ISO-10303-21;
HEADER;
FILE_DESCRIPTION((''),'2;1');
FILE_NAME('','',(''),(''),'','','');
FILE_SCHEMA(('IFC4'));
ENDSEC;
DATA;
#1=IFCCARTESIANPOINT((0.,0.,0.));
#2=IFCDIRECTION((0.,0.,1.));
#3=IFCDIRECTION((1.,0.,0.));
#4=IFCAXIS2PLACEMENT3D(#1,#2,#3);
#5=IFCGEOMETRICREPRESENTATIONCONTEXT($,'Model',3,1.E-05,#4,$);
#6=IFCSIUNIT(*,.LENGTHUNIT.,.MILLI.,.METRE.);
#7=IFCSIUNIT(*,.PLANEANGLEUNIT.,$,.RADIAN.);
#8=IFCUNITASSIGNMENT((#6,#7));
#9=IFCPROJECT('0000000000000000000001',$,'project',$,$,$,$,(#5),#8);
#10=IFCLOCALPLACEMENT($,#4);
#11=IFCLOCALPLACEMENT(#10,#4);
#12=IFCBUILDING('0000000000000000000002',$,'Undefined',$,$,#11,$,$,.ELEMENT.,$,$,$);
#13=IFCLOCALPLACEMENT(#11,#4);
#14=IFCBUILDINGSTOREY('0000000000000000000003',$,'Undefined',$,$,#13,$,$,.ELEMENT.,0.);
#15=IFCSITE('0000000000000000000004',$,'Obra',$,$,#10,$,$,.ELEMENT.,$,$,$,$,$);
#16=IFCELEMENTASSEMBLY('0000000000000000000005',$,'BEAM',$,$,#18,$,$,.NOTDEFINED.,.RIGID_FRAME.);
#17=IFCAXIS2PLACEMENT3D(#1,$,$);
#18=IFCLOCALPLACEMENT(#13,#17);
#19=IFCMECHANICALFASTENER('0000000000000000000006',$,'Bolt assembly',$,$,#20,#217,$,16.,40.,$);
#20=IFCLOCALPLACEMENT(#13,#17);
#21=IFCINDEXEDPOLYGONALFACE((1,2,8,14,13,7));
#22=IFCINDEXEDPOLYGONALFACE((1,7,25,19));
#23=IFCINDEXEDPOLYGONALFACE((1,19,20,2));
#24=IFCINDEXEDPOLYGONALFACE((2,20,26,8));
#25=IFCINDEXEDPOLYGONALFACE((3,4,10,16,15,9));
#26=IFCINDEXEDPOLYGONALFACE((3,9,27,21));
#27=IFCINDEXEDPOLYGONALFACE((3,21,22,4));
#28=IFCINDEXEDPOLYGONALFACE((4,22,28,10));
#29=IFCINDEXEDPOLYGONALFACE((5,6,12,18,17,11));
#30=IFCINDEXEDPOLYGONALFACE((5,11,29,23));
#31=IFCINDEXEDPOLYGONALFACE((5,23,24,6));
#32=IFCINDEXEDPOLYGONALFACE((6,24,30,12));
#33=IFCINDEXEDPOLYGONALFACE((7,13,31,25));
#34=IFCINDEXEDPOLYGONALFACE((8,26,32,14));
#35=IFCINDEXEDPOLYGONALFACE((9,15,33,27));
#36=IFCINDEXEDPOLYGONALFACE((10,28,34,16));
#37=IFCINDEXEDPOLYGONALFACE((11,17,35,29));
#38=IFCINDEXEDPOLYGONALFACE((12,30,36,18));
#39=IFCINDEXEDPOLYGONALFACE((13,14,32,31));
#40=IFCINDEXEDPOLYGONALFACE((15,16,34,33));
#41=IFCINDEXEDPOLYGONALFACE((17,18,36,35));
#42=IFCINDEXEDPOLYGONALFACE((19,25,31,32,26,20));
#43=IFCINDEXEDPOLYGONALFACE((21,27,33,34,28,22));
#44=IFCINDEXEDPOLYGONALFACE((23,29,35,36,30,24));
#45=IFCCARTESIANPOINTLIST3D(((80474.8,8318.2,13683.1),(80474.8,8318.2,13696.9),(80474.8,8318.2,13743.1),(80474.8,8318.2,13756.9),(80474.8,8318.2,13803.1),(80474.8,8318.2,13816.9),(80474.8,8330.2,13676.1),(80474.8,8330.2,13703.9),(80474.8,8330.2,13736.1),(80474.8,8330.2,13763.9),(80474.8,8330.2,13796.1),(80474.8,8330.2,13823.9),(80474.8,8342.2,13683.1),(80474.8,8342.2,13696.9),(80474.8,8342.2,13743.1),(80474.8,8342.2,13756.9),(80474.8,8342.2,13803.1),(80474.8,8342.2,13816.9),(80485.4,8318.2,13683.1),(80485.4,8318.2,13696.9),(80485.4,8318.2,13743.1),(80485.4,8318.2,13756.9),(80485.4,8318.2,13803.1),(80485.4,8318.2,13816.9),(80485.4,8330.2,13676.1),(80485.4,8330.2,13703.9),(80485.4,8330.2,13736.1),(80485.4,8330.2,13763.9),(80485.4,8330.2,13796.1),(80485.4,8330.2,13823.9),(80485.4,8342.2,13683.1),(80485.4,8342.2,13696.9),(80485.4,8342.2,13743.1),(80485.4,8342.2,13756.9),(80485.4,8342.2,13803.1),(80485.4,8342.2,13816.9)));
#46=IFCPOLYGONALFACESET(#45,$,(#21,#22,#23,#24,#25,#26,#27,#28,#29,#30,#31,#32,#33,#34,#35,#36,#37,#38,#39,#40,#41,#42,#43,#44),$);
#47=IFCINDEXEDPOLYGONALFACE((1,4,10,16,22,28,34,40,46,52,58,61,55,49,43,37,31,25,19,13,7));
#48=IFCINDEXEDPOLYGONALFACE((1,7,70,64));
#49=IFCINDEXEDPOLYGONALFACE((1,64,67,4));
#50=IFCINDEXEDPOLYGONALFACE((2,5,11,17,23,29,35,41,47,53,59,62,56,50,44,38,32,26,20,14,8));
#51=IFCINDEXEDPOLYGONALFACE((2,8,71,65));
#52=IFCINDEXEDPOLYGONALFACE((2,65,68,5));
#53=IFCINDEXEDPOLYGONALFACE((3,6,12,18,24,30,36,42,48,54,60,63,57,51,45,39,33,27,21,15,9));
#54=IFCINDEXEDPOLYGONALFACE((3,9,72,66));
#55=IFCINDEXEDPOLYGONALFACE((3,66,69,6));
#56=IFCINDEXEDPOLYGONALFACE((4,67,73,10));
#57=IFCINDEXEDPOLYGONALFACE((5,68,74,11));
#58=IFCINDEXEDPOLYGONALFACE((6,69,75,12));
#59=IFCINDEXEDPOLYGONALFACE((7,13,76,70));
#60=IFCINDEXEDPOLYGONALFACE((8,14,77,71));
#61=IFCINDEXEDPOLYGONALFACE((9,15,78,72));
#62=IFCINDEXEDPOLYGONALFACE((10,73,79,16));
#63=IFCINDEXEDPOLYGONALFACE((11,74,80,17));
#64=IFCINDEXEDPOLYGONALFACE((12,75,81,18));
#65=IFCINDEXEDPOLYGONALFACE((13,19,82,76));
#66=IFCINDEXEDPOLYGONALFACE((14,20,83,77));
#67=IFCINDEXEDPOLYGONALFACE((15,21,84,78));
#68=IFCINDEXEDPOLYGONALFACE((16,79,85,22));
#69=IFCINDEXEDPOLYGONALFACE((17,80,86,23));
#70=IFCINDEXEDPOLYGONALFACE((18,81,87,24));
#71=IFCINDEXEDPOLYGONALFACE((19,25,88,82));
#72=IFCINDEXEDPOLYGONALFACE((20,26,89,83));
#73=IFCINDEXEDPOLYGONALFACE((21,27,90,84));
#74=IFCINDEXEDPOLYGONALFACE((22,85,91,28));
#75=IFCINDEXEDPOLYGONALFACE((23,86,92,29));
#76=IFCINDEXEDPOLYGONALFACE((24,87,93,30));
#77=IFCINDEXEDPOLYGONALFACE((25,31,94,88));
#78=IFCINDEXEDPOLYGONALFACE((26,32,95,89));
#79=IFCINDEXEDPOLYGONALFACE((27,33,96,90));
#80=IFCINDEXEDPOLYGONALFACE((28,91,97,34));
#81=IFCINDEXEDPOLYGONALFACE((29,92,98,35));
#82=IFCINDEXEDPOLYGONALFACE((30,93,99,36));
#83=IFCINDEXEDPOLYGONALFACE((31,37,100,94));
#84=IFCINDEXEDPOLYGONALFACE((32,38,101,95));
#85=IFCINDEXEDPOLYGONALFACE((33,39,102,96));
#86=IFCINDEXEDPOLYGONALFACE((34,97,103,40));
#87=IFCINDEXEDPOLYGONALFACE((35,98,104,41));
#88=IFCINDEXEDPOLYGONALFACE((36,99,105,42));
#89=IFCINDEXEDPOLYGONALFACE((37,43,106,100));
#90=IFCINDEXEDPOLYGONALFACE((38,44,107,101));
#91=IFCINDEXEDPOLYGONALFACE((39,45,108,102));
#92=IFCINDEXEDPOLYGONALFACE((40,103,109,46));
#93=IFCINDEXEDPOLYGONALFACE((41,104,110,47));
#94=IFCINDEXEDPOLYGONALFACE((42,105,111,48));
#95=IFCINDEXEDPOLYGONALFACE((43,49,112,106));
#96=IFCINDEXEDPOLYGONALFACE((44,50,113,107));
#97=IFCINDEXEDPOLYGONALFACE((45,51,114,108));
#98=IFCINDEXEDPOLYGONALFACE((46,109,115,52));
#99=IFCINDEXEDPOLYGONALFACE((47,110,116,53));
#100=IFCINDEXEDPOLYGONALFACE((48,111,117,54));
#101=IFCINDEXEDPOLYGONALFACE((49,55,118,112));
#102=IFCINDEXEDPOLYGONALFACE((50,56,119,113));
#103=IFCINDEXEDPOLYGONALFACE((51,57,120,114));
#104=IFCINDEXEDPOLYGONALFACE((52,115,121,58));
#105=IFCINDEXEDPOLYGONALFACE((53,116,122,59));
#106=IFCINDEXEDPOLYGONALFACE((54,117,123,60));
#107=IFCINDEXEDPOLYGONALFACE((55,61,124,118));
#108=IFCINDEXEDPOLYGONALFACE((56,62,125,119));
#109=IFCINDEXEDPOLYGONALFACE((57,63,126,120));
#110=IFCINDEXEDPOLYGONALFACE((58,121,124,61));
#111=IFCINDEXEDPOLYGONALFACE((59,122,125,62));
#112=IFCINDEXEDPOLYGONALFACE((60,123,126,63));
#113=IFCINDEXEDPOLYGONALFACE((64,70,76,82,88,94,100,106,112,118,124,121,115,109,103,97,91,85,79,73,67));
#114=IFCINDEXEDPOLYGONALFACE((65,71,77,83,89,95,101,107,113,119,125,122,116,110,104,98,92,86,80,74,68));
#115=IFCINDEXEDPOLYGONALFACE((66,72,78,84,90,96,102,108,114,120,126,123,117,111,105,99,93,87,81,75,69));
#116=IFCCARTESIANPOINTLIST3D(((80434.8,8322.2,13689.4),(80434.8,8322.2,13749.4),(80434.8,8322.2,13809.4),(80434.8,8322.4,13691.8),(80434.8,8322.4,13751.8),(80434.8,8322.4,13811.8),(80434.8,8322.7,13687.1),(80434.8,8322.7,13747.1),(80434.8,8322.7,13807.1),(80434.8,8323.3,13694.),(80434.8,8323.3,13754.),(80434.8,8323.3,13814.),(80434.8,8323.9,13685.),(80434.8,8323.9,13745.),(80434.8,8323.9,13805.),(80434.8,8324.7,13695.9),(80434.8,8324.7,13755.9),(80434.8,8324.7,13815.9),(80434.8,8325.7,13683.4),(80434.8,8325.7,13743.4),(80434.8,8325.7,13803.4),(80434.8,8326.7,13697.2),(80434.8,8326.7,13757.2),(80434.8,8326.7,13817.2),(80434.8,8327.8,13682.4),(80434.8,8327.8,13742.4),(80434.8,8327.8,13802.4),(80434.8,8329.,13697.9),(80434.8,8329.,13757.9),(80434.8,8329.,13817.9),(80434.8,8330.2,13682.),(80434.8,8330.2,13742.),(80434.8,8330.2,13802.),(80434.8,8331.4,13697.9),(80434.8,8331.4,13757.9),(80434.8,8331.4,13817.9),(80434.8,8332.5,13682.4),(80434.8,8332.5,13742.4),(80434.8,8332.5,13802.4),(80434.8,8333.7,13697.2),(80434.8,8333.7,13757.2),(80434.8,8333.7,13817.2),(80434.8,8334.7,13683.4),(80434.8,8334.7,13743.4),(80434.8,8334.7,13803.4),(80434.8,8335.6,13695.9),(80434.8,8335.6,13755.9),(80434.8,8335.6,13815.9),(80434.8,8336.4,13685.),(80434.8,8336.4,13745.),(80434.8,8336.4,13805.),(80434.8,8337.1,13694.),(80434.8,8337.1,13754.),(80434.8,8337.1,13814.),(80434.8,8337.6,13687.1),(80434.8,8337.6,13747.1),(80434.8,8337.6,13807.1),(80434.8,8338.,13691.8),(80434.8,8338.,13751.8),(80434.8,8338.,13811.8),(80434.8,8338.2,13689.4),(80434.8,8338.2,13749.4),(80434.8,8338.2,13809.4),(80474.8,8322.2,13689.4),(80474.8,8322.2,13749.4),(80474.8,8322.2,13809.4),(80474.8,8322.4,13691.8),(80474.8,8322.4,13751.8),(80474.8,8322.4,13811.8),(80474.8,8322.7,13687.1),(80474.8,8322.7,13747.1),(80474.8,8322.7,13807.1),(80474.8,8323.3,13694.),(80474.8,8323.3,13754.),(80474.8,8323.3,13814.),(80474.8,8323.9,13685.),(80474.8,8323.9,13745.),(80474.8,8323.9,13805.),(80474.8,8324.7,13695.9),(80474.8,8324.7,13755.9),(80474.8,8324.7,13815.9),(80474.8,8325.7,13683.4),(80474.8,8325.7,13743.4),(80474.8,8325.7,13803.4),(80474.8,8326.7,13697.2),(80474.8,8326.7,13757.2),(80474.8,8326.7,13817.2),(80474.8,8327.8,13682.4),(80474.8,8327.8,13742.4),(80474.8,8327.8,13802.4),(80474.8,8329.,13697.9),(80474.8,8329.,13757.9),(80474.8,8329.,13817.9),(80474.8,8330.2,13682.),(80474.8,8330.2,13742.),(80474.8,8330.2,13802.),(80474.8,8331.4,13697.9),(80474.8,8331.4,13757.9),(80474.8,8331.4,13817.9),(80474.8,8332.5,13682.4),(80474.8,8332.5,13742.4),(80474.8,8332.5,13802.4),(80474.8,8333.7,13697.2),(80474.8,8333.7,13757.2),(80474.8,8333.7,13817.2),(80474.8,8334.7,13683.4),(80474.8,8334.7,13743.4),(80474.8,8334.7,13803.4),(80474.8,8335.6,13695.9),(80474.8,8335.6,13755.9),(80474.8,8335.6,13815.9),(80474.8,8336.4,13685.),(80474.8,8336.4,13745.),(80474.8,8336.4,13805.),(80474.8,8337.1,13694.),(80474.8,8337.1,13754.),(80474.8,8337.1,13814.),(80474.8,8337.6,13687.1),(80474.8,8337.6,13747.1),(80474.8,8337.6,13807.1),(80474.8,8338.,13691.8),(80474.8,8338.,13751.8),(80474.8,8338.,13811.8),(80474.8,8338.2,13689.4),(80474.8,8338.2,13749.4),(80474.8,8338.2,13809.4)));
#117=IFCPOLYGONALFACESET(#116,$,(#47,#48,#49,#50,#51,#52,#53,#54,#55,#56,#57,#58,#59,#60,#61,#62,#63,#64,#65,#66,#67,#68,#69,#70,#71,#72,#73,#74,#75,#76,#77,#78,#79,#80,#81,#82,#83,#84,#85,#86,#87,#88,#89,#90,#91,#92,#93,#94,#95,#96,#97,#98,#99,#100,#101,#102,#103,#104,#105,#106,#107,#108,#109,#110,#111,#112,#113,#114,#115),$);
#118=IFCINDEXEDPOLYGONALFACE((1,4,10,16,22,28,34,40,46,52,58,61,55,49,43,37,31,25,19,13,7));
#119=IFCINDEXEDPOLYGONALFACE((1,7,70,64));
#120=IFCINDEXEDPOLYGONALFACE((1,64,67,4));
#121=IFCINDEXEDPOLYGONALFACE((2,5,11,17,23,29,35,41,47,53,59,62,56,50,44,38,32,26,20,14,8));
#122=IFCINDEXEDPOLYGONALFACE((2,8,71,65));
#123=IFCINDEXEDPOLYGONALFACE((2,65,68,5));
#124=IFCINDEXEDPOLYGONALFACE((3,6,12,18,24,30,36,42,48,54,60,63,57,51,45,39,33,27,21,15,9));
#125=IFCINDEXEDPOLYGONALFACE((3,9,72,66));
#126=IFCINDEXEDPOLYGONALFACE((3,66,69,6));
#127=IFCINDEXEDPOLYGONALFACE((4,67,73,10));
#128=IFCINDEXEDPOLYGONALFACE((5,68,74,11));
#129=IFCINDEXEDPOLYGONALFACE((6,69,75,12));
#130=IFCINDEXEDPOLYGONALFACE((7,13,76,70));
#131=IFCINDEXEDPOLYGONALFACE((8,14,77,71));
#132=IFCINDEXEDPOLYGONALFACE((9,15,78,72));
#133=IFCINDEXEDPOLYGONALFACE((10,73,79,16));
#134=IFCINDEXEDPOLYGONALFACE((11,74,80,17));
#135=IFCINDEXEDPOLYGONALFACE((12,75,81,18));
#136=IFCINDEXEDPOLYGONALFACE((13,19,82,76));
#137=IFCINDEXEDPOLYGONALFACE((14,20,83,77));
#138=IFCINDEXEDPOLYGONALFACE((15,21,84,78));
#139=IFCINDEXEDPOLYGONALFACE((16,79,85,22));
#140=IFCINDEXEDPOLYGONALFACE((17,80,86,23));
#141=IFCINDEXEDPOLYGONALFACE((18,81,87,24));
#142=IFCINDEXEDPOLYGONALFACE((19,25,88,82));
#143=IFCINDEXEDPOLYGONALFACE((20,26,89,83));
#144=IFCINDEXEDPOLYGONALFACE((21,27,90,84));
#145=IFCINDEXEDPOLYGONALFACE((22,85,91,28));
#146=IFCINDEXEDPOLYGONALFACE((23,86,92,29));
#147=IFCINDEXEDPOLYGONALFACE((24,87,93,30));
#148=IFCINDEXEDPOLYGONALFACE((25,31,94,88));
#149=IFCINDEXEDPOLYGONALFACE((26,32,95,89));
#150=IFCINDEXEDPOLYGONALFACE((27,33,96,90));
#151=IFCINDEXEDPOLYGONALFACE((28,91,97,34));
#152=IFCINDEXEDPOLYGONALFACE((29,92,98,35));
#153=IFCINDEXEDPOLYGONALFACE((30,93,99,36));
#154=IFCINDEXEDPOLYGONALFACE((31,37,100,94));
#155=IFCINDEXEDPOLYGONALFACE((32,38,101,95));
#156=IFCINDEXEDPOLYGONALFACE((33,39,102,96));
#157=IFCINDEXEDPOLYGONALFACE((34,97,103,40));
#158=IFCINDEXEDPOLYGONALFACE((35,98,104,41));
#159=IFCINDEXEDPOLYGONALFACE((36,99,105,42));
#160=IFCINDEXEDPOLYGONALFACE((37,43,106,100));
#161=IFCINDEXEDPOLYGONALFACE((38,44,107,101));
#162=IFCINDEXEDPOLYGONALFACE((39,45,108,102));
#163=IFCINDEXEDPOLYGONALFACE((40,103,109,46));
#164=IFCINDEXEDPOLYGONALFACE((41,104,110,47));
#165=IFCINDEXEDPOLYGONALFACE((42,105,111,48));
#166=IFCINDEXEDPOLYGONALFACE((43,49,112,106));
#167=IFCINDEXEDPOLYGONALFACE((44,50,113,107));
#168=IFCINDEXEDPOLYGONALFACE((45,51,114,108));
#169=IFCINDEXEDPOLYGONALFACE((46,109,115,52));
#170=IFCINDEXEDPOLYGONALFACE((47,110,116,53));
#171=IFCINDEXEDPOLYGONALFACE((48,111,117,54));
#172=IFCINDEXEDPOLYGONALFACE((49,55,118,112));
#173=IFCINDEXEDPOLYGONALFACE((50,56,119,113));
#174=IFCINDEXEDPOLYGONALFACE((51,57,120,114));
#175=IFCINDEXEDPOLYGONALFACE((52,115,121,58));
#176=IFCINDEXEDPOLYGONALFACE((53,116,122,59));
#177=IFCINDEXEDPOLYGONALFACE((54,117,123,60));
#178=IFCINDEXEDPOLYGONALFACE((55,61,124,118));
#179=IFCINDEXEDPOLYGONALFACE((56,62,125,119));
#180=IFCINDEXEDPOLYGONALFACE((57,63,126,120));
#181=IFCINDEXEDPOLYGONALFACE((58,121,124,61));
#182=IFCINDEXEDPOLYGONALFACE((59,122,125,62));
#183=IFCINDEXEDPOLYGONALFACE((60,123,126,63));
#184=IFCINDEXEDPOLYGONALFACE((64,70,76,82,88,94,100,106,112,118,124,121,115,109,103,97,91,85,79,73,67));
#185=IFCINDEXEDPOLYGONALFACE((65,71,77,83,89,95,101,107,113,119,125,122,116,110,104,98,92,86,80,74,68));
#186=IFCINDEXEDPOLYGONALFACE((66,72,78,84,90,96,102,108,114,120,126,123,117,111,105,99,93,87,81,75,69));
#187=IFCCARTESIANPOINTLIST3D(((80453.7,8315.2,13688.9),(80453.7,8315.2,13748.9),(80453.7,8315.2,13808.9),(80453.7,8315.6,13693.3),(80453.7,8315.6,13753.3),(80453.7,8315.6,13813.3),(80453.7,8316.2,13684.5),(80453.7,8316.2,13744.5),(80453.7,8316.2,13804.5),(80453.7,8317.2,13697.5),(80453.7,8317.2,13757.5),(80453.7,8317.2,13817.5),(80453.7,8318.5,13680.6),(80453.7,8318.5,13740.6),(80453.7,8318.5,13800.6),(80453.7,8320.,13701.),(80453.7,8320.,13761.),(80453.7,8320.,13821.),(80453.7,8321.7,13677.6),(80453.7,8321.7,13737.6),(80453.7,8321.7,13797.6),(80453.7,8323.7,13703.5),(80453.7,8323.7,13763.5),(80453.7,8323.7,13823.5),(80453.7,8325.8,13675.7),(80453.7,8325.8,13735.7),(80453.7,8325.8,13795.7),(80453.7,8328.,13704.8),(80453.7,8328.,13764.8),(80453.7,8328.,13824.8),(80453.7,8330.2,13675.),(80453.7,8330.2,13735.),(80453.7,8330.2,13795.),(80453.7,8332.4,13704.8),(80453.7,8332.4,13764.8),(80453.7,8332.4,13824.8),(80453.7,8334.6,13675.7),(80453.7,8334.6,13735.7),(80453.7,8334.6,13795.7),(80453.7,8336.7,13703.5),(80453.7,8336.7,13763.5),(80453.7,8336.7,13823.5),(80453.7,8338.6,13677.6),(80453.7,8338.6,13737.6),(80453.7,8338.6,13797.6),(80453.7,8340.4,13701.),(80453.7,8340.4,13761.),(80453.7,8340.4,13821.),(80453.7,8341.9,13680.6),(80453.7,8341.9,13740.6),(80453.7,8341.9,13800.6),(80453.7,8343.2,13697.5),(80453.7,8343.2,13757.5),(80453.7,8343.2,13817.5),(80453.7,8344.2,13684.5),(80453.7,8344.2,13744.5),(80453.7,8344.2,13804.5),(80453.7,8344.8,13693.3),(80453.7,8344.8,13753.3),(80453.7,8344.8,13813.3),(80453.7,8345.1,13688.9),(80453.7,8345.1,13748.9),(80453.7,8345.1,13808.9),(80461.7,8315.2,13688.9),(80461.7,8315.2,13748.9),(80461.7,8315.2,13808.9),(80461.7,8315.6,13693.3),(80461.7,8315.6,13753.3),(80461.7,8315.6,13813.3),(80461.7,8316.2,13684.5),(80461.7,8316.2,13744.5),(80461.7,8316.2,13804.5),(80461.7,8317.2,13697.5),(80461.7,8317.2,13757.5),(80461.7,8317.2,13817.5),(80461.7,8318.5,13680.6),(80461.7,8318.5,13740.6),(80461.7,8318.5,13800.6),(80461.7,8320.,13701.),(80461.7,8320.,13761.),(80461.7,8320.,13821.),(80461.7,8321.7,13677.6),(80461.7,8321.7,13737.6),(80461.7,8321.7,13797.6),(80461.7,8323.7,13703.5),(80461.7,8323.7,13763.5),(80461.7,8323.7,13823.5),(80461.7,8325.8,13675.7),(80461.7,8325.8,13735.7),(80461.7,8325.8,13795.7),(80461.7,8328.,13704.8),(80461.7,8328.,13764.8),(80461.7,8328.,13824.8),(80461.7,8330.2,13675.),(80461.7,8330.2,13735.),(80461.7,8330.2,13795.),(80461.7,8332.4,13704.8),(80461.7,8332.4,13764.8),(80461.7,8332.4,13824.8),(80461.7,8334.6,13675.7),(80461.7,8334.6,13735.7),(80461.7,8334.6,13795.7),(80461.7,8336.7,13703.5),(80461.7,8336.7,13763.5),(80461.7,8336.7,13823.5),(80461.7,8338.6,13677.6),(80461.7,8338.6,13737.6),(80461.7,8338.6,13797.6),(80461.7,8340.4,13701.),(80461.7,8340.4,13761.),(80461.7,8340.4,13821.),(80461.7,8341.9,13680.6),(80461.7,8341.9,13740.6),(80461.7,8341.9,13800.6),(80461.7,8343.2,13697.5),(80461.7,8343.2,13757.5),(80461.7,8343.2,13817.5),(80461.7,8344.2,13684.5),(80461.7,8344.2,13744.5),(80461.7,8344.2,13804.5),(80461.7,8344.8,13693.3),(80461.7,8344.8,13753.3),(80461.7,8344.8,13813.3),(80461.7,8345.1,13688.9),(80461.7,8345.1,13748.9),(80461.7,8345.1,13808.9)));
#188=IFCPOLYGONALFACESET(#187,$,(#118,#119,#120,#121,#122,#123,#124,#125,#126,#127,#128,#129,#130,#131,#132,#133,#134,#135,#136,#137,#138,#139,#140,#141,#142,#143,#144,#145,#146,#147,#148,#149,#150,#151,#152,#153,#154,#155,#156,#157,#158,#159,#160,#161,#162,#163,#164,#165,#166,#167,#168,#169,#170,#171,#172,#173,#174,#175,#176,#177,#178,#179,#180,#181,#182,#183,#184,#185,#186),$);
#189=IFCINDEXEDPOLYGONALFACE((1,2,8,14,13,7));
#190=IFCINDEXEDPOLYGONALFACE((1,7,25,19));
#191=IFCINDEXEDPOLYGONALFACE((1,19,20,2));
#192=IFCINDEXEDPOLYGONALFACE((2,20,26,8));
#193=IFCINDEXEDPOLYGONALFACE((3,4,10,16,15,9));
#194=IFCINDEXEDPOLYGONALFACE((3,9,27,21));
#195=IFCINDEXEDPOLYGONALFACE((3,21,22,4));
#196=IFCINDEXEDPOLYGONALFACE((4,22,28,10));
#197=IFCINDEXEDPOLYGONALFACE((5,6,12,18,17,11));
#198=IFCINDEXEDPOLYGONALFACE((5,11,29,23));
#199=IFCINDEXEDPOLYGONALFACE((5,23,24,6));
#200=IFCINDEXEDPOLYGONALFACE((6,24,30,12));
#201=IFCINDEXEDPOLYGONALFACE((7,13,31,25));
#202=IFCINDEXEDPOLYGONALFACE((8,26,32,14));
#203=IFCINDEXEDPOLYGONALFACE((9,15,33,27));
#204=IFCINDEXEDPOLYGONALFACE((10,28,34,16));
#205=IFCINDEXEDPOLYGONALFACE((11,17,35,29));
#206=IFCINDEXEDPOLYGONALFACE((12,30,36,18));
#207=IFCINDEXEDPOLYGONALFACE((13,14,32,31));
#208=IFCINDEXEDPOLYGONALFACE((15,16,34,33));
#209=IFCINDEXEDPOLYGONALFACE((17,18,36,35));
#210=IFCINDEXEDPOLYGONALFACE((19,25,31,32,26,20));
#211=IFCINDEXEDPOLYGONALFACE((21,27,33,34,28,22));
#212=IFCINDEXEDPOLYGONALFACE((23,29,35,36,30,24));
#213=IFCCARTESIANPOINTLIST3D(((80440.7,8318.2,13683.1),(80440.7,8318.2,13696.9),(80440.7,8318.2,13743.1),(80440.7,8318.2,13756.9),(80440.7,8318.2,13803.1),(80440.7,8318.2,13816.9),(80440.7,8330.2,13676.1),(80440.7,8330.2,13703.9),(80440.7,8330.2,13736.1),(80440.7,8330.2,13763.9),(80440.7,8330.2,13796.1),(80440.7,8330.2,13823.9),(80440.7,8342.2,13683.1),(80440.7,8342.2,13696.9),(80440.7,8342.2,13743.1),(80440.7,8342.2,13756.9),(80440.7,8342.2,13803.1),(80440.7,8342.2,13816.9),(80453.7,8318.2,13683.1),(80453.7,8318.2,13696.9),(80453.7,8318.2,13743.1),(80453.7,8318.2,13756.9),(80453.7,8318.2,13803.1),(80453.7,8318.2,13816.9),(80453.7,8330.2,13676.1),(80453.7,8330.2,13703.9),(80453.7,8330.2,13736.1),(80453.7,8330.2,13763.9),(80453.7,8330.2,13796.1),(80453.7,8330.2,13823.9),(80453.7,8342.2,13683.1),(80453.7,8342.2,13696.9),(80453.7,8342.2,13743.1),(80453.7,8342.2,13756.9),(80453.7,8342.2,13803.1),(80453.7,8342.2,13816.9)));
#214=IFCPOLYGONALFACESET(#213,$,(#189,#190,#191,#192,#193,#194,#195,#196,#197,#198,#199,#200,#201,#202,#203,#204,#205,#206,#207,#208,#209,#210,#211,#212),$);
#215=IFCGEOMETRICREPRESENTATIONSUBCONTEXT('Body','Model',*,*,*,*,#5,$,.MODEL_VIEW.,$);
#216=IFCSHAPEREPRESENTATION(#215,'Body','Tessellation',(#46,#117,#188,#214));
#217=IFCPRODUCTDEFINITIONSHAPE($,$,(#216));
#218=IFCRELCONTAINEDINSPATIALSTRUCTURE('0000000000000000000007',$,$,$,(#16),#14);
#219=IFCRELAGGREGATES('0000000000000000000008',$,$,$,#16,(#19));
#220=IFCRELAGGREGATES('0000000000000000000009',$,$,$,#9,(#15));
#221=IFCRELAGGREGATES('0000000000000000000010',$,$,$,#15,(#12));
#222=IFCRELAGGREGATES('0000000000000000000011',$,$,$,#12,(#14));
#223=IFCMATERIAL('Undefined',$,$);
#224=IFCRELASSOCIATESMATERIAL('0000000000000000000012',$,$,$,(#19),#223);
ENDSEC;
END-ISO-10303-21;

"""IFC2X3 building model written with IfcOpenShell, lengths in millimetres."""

from ifc_helpers import new_model, si_unit, frame, origin_with_axes, origin_2d_with_axis, place, context, subcontext, project, spatial, polyline, circle, outline, extrude, source, transform, mapped, material, element, aggregate, save


model = new_model("IFC2X3")

# Units and contexts
model_context = context("Model", 3, precision=1e-05, world=origin_with_axes())
body_context = subcontext(model_context, "Body", "Model", "MODEL_VIEW")
ifc_project = project(units=[si_unit("LENGTHUNIT", "METRE", prefix="MILLI"), si_unit("PLANEANGLEUNIT", "RADIAN")], contexts=[model_context])

# Site, building, storey
site_placement = place(None, origin_with_axes())
site = spatial("IfcSite", under=ifc_project, at=site_placement, Name="Obra", CompositionType="ELEMENT")
building_placement = place(site_placement, origin_with_axes())
building = spatial("IfcBuilding", under=site, at=building_placement, Name="Undefined", CompositionType="ELEMENT")
storey_placement = place(building_placement, origin_with_axes())
storey = spatial("IfcBuildingStorey", under=building, at=storey_placement, Name="Undefined", CompositionType="ELEMENT", Elevation=0.0)

# Shared definitions
ifc_material_1 = material(Name="Undefined")

# Element assembly, mechanical fastener
assembly_1_placement = place(storey_placement, origin_with_axes())
assembly_1 = element("IfcElementAssembly", 1, at=assembly_1_placement, inside=storey, Name="BEAM", AssemblyPlace="NOTDEFINED", PredefinedType="RIGID_FRAME")
shared_shape_1 = source(origin_with_axes(), body_context, "Body", "SweptSolid", [
    extrude(outline(polyline([(13.9, 0.0), (6.9, 12.0), (-6.9, 12.0), (-13.9, 0.0), (-6.9, -12.0), (6.9, -12.0), (13.9, 0.0)])), frame((0.0, -20.1, 0.0), z_axis=(0.0, 1.0, 0.0), x_axis=(1.0, 0.0, 0.0)), (0.0, 0.0, 1.0), 10.6),
    extrude(circle(Radius=8.0, at=origin_2d_with_axis()), frame((0.0, -9.6, 0.0), z_axis=(0.0, 1.0, 0.0), x_axis=(1.0, 0.0, 0.0)), (0.0, 0.0, 1.0), 40.0),
    extrude(circle(Radius=15.0, at=origin_2d_with_axis()), frame((0.0, 3.5, 0.0), z_axis=(0.0, 1.0, 0.0), x_axis=(1.0, 0.0, 0.0)), (0.0, 0.0, 1.0), 8.0),
    extrude(outline(polyline([(13.9, 0.0), (6.9, 12.0), (-6.9, 12.0), (-13.9, 0.0), (-6.9, -12.0), (6.9, -12.0), (13.9, 0.0)])), frame((0.0, 11.5, 0.0), z_axis=(0.0, 1.0, 0.0), x_axis=(1.0, 0.0, 0.0)), (0.0, 0.0, 1.0), 13.0),
])
mechanical_fastener_1_placement = place(assembly_1_placement, frame((80465.3, 8280.2, 13845.0), z_axis=(-0.000014, 1.0, 0.0), x_axis=(0.0, 0.0, -1.0)))
mechanical_fastener_1 = element("IfcMechanicalFastener", 2, at=mechanical_fastener_1_placement, material=ifc_material_1, Name="Bolt assembly", NominalDiameter=16.0, NominalLength=40.0, context=body_context, shape_type="MappedRepresentation", body=[
    mapped(shared_shape_1, transform((35.0, 0.0, 50.0))),
    mapped(shared_shape_1, transform((95.0, 0.0, 50.0))),
    mapped(shared_shape_1, transform((155.0, 0.0, 50.0))),
])
aggregate(assembly_1, [mechanical_fastener_1])

save(model, "model.ifc")
